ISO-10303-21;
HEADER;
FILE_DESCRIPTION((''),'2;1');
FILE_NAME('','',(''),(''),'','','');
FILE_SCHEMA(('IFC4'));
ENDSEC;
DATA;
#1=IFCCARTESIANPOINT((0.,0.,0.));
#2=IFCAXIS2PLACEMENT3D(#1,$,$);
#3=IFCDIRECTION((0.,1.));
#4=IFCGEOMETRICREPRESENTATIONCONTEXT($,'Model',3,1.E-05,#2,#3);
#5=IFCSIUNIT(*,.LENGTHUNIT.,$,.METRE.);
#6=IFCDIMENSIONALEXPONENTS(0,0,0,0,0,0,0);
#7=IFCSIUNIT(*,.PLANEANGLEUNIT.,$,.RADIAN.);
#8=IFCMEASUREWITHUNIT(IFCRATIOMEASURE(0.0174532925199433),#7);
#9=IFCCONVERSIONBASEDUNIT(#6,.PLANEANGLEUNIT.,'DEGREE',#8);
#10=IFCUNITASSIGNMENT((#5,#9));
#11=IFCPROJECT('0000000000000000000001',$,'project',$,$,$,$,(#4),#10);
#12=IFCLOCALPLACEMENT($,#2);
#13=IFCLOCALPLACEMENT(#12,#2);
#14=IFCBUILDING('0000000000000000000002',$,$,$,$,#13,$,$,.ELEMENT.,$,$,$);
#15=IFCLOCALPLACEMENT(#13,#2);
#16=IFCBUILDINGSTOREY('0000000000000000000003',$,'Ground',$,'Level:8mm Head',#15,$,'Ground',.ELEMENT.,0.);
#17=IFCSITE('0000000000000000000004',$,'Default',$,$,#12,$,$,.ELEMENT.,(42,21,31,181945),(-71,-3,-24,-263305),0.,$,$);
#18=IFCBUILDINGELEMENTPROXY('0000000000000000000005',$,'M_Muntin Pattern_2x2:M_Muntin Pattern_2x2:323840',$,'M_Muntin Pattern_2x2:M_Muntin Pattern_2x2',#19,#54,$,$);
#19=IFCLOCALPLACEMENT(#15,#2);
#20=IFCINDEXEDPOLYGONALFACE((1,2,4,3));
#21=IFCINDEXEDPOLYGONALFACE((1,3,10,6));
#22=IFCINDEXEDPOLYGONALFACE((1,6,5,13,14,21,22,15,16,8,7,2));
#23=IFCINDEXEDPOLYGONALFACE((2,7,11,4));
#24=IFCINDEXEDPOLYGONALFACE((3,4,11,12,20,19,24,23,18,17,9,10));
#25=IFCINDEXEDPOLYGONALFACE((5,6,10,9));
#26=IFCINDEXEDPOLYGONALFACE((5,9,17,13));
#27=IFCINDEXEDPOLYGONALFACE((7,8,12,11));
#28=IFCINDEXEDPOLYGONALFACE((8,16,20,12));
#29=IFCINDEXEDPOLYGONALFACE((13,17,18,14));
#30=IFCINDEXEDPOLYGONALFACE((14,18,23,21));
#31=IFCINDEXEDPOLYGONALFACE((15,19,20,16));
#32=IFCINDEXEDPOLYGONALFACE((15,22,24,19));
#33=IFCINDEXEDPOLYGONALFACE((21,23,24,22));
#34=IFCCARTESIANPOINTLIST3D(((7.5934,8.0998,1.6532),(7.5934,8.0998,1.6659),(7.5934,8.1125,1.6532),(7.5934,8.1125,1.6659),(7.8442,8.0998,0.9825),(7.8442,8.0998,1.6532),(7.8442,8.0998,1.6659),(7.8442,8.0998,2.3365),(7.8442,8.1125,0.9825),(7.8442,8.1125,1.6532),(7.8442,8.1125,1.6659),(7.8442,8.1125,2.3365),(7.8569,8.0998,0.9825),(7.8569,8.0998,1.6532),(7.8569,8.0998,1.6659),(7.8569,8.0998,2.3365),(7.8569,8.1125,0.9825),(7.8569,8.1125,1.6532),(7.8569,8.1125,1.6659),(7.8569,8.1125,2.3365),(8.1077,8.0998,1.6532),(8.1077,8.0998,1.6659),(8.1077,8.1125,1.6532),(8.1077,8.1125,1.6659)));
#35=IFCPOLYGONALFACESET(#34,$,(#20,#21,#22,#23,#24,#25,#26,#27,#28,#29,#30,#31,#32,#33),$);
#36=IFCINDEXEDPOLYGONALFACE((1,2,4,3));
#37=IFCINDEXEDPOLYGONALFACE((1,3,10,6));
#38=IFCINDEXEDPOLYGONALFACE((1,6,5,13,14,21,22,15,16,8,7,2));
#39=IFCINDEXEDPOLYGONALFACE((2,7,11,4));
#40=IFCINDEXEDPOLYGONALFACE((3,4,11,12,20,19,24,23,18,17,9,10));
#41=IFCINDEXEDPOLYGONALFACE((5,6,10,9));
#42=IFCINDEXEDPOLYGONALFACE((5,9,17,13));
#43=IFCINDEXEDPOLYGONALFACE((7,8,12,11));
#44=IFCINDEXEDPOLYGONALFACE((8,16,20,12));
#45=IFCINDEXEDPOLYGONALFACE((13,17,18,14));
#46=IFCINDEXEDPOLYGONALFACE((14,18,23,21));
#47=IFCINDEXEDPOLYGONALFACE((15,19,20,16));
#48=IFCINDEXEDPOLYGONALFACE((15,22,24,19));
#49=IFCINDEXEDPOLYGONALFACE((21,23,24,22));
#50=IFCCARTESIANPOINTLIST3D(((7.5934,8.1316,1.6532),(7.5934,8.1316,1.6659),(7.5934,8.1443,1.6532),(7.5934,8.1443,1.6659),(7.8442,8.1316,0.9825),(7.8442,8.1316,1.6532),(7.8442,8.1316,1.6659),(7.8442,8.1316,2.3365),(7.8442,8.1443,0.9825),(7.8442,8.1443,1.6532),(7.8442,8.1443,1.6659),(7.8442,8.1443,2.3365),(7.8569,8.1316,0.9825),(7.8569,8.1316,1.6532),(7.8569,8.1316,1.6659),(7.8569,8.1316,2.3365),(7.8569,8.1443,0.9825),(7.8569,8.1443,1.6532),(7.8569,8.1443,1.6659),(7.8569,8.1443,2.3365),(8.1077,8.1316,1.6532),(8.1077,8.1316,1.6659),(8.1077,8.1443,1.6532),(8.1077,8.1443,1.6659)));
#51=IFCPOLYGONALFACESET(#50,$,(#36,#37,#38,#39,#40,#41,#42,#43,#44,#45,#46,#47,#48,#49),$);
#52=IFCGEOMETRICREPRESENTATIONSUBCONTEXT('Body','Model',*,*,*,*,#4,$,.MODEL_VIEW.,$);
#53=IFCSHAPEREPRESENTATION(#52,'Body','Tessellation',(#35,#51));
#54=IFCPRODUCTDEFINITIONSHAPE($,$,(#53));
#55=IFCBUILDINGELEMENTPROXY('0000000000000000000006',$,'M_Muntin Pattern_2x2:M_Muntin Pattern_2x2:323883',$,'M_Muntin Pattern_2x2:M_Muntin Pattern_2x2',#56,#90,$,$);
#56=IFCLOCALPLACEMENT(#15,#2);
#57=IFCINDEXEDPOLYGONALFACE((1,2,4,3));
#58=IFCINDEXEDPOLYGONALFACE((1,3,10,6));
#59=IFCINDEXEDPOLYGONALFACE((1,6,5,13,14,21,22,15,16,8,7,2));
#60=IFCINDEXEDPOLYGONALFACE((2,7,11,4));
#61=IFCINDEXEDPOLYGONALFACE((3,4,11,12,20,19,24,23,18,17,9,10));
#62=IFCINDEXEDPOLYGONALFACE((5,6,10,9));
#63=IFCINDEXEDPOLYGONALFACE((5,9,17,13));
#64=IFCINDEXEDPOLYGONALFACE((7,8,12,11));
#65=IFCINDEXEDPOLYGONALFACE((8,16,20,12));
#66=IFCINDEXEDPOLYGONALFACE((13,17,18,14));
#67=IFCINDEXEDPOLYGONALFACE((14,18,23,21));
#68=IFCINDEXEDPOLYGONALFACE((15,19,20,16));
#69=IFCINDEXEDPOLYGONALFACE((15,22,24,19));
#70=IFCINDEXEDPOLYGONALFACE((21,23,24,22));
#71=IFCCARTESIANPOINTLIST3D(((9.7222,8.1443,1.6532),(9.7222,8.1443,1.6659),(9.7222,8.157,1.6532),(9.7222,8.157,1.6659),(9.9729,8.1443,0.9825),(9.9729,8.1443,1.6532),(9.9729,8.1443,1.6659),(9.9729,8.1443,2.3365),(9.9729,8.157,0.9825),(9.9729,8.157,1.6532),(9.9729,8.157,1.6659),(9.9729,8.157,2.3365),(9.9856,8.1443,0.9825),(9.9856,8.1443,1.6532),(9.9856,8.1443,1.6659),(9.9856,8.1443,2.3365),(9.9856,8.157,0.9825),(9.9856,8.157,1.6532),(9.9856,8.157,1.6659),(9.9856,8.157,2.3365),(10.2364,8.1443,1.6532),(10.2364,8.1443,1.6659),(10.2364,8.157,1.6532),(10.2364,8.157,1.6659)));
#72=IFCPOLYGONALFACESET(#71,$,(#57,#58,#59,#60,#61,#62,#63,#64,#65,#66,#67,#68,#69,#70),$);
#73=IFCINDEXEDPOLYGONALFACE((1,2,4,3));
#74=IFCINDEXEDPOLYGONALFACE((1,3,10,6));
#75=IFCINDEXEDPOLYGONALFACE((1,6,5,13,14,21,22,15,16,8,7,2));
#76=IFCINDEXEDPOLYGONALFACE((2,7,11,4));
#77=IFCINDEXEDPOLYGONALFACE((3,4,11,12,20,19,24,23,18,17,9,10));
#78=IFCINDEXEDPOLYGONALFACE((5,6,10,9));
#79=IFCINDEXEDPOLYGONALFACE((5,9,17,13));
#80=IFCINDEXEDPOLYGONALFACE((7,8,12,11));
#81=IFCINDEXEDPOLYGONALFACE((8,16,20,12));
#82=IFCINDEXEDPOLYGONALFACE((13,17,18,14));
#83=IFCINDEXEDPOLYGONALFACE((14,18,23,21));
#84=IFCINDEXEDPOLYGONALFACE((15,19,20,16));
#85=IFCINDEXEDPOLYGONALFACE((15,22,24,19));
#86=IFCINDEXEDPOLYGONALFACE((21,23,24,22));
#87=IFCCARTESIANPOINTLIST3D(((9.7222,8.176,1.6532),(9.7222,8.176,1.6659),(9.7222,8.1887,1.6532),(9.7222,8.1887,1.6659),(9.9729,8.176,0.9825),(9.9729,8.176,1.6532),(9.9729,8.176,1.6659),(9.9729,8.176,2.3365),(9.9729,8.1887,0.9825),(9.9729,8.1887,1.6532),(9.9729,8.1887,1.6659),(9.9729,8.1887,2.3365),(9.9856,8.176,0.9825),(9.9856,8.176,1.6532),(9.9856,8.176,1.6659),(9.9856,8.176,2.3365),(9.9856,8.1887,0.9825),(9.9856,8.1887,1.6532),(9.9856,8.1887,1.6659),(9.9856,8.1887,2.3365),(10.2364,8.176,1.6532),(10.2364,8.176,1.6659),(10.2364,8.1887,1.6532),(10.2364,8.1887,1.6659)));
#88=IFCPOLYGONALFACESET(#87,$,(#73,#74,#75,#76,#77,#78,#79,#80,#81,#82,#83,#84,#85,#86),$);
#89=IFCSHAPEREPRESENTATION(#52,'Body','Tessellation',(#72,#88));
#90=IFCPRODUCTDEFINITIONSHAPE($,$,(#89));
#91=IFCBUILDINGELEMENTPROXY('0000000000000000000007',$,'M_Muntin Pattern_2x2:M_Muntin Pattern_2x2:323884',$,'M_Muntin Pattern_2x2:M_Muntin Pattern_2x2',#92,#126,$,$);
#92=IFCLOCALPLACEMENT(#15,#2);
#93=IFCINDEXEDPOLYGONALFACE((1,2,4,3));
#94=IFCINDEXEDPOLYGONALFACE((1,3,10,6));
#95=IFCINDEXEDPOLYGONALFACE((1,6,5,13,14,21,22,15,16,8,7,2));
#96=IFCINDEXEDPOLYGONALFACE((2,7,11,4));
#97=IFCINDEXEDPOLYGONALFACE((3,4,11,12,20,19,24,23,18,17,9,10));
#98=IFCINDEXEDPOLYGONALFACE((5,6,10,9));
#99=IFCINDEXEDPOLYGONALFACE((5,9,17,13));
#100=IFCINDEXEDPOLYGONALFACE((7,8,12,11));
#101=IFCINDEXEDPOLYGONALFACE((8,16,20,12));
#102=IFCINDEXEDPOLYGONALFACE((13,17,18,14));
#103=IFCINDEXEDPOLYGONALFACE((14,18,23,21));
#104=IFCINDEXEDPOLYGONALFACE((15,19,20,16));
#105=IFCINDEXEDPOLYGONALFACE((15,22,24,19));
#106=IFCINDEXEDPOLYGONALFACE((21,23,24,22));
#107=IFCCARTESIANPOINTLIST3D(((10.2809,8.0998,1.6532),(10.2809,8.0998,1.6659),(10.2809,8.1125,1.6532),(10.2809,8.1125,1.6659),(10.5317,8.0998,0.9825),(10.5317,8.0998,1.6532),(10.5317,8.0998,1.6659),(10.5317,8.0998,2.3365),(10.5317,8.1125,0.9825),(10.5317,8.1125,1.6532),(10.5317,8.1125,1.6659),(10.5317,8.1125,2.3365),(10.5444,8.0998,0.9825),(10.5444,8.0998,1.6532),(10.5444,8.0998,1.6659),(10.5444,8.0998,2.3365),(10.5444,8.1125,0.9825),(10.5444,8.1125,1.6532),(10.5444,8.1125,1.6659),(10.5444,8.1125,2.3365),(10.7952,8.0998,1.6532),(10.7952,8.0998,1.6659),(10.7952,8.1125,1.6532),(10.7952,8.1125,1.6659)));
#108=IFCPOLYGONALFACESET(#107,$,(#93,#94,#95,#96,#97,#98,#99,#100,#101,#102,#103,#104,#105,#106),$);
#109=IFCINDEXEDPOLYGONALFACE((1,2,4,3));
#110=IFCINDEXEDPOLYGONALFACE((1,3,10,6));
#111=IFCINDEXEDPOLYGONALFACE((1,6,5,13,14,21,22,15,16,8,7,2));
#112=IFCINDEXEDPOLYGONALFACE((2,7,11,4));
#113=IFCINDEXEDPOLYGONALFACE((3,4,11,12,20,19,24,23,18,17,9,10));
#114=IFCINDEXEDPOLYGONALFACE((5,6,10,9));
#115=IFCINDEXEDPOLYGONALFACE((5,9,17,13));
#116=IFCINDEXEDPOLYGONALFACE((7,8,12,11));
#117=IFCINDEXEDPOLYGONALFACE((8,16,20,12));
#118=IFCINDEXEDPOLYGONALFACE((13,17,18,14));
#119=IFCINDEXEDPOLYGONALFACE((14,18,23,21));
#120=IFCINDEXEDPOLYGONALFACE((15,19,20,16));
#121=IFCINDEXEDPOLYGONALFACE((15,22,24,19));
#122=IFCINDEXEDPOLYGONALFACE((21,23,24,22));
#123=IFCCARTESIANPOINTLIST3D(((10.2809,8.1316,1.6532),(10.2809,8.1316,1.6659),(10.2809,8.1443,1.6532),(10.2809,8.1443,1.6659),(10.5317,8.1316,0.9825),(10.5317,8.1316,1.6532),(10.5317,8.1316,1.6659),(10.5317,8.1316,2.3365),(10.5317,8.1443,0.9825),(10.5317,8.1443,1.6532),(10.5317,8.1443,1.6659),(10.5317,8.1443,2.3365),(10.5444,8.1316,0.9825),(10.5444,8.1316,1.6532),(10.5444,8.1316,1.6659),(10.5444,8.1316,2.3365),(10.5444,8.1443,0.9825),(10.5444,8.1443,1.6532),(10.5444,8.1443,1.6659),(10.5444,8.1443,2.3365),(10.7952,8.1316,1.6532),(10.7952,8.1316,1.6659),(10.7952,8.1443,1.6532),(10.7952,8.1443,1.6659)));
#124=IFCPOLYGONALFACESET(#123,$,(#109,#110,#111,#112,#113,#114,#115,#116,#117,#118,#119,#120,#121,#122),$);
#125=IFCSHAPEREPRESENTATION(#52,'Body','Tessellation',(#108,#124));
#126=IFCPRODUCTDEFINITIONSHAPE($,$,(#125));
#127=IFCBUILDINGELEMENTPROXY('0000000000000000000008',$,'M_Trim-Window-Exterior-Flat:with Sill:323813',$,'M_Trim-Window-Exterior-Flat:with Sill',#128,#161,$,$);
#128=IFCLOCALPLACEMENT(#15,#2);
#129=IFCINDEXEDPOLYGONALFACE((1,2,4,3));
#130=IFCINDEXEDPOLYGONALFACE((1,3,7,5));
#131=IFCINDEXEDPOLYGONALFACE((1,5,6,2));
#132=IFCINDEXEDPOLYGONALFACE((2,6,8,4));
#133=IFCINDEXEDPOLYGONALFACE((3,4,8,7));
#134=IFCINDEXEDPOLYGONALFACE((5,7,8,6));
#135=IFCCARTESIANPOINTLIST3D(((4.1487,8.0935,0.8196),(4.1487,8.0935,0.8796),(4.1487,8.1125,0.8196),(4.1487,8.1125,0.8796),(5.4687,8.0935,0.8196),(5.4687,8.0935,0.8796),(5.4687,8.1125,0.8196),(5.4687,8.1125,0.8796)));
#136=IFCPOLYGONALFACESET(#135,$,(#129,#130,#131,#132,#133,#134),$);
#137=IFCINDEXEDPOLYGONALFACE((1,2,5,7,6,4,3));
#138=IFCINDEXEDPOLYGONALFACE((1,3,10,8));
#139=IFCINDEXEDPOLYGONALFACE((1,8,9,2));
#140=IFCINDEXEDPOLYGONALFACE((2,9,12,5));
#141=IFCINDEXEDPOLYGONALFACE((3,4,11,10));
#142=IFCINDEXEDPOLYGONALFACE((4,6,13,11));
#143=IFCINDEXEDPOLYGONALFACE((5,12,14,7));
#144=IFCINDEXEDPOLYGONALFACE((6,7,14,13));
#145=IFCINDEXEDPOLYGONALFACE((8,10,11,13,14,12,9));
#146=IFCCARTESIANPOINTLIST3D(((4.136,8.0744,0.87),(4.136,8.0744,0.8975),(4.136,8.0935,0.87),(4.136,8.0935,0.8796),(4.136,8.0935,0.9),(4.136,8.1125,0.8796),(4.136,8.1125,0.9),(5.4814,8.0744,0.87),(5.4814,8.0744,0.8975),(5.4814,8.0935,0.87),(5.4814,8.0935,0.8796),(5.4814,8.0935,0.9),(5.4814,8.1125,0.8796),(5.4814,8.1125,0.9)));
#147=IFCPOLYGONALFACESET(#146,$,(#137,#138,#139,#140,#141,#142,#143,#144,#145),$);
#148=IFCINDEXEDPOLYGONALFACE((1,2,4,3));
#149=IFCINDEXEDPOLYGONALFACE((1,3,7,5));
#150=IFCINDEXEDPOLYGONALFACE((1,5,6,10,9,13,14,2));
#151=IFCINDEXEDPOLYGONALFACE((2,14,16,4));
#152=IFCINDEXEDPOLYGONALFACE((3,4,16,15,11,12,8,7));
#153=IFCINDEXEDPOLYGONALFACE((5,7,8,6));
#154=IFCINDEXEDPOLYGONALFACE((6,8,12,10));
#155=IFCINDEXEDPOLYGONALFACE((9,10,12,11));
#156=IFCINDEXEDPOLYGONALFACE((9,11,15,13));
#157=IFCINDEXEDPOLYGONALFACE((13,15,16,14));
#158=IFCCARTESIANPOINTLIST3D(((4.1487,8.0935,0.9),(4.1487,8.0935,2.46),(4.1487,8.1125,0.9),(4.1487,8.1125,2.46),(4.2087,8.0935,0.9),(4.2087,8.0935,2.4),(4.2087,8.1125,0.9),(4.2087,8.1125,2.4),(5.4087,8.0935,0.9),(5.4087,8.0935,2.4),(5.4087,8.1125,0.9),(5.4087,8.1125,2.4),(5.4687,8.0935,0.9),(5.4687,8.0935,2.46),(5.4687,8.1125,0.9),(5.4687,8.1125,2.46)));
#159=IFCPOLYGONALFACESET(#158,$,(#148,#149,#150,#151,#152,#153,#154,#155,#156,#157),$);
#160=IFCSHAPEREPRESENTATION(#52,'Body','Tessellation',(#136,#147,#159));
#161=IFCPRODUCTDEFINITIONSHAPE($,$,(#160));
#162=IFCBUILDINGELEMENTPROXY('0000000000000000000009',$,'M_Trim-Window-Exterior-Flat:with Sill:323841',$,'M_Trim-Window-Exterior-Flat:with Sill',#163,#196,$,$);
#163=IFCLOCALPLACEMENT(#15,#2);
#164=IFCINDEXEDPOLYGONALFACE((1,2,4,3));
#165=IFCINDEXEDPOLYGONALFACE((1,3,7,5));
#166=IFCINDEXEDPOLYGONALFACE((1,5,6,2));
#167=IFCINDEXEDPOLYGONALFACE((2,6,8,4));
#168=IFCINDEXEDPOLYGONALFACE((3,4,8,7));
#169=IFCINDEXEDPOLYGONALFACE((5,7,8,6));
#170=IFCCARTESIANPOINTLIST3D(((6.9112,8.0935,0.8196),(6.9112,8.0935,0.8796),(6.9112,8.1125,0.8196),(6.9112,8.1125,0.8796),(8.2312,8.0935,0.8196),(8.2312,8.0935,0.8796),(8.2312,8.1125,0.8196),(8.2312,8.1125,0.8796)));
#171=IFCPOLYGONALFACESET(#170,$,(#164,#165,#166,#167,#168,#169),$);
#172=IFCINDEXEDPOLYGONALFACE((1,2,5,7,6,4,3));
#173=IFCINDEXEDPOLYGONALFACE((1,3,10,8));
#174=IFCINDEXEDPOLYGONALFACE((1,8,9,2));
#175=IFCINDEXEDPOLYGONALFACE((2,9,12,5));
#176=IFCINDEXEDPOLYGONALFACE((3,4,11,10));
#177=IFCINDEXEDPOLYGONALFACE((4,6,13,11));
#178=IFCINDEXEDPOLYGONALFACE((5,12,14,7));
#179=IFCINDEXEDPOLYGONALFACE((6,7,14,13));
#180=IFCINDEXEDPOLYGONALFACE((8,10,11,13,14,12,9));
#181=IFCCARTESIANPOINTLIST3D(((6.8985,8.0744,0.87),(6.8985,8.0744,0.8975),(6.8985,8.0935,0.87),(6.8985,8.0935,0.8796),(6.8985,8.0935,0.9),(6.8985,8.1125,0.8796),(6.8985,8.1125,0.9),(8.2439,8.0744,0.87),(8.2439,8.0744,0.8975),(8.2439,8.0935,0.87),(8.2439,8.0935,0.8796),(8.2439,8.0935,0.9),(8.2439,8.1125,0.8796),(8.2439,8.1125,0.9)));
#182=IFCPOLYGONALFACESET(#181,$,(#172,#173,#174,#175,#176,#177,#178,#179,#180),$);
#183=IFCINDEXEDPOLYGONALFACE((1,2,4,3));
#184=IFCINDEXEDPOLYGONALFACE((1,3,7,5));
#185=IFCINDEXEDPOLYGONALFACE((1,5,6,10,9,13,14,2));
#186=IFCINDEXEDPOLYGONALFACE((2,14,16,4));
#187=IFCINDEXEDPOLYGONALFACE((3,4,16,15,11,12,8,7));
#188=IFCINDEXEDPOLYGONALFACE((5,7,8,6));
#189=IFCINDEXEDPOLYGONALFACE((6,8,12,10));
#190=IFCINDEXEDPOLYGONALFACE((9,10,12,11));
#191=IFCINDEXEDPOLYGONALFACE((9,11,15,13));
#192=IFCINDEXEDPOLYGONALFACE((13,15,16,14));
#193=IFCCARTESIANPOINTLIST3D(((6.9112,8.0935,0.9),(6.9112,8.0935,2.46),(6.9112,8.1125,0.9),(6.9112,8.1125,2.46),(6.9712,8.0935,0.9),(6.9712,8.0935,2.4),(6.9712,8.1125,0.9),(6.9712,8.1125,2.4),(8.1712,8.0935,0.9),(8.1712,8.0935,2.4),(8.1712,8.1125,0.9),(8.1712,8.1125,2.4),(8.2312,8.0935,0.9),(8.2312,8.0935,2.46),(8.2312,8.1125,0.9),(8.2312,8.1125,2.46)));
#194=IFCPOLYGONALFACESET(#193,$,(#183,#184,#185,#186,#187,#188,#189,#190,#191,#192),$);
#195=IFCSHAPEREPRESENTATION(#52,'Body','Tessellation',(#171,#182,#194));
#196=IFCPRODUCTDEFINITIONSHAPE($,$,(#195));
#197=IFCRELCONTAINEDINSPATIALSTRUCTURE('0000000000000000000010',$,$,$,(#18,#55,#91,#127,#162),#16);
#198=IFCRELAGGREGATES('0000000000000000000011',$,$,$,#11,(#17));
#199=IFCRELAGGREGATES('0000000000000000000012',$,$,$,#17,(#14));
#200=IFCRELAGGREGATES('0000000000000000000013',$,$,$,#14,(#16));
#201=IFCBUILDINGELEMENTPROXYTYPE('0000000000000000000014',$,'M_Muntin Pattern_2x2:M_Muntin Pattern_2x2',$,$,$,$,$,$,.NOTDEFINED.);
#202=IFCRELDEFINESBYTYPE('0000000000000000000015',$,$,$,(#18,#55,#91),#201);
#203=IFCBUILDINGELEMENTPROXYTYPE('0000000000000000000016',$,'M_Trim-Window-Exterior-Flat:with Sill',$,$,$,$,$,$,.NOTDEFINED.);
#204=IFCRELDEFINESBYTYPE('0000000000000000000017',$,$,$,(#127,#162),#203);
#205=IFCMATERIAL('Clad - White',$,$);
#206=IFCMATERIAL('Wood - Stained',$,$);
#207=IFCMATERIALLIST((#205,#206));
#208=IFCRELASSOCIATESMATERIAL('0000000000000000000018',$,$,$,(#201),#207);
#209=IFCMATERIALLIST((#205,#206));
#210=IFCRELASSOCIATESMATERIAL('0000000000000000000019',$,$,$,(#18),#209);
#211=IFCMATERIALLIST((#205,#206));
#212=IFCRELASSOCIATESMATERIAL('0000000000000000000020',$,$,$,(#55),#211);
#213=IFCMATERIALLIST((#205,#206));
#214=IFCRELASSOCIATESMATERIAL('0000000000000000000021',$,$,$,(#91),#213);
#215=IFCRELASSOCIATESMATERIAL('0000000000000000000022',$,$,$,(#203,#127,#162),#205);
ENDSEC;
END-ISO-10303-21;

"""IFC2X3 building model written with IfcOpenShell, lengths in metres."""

from ifc_helpers import new_model, entity, si_unit, converted_unit, direction, frame, frame_2d, origin, place, context, subcontext, project, spatial, polyline, rectangle, outline, extrude, source, transform, mapped, material, material_list, type_object, type_shapes, element, save


model = new_model("IFC2X3")

# Units and contexts
model_context = context("Model", 3, precision=1e-05, world=origin(), true_north=direction((0.0, 1.0)))
body_context = subcontext(model_context, "Body", "Model", "MODEL_VIEW")
ifc_project = project(units=[si_unit("LENGTHUNIT", "METRE"), converted_unit("PLANEANGLEUNIT", "DEGREE", entity("IfcRatioMeasure", 0.0174532925199433), si_unit("PLANEANGLEUNIT", "RADIAN"), dimensions=[0, 0, 0, 0, 0, 0, 0])], contexts=[model_context])

# Site, building, storey
site_placement = place(None, origin())
site = spatial("IfcSite", under=ifc_project, at=site_placement, Name="Default", CompositionType="ELEMENT", RefLatitude=(42, 21, 31, 181945), RefLongitude=(-71, -3, -24, -263305), RefElevation=0.0)
building_placement = place(site_placement, origin())
building = spatial("IfcBuilding", under=site, at=building_placement, CompositionType="ELEMENT")
storey_placement = place(building_placement, origin())
storey = spatial("IfcBuildingStorey", under=building, at=storey_placement, Name="Ground", ObjectType="Level:8mm Head", LongName="Ground", CompositionType="ELEMENT", Elevation=0.0)

# Building element proxies
ifc_material_1 = material(Name="Clad - White")
ifc_material_2 = material(Name="Wood - Stained")
ifc_material_list_1 = material_list([ifc_material_1, ifc_material_2])
building_element_proxy_type_1 = type_object("IfcBuildingElementProxyType", Name="M_Muntin Pattern_2x2:M_Muntin Pattern_2x2", PredefinedType="NOTDEFINED", material=ifc_material_list_1)
shared_shape_1 = source(origin(), body_context, "Body", "SweptSolid", [
    extrude(outline(polyline([(0.0064, -0.0064), (0.677, -0.0064), (0.677, 0.0063), (0.0064, 0.0063), (0.0064, 0.2571), (-0.0063, 0.2571), (-0.0063, 0.0063), (-0.677, 0.0063), (-0.677, -0.0064), (-0.0063, -0.0064), (-0.0063, -0.2571), (0.0064, -0.2571), (0.0064, -0.0064)])), frame((0.0, 0.0095, 0.677), z_axis=(0.0, 1.0, 0.0), x_axis=(0.0, 0.0, 1.0)), (0.0, 0.0, 1.0), 0.0127),
    extrude(outline(polyline([(0.0064, -0.0064), (0.677, -0.0064), (0.677, 0.0063), (0.0064, 0.0063), (0.0064, 0.2571), (-0.0063, 0.2571), (-0.0063, 0.0063), (-0.677, 0.0063), (-0.677, -0.0064), (-0.0063, -0.0064), (-0.0063, -0.2571), (0.0064, -0.2571), (0.0064, -0.0064)])), frame((0.0, -0.0222, 0.677), z_axis=(0.0, 1.0, 0.0), x_axis=(0.0, 0.0, 1.0)), (0.0, 0.0, 1.0), 0.0127),
])
type_shapes(building_element_proxy_type_1, [shared_shape_1])
ifc_material_list_2 = material_list([ifc_material_1, ifc_material_2])
proxy_1_placement = place(storey_placement, frame((7.8505, 8.1221, 0.9825), z_axis=(0.0, 0.0, 1.0), x_axis=(-1.0, 0.0, 0.0)))
element("IfcBuildingElementProxy", 1, at=proxy_1_placement, inside=storey, type_object=building_element_proxy_type_1, material=ifc_material_list_2, Name="M_Muntin Pattern_2x2:M_Muntin Pattern_2x2:323840", ObjectType="M_Muntin Pattern_2x2:M_Muntin Pattern_2x2", context=body_context, shape_type="MappedRepresentation", body=[
    mapped(shared_shape_1, transform((0.0, 0.0, 0.0), scale=1.0)),
])
ifc_material_list_3 = material_list([ifc_material_1, ifc_material_2])
proxy_2_placement = place(storey_placement, frame((9.9793, 8.1665, 0.9825), z_axis=(0.0, 0.0, 1.0), x_axis=(-1.0, 0.0, 0.0)))
element("IfcBuildingElementProxy", 2, at=proxy_2_placement, inside=storey, type_object=building_element_proxy_type_1, material=ifc_material_list_3, Name="M_Muntin Pattern_2x2:M_Muntin Pattern_2x2:323883", ObjectType="M_Muntin Pattern_2x2:M_Muntin Pattern_2x2", context=body_context, shape_type="MappedRepresentation", body=[
    mapped(shared_shape_1, transform((0.0, 0.0, 0.0), scale=1.0)),
])
ifc_material_list_4 = material_list([ifc_material_1, ifc_material_2])
proxy_3_placement = place(storey_placement, frame((10.538, 8.1221, 0.9825), z_axis=(0.0, 0.0, 1.0), x_axis=(-1.0, 0.0, 0.0)))
element("IfcBuildingElementProxy", 3, at=proxy_3_placement, inside=storey, type_object=building_element_proxy_type_1, material=ifc_material_list_4, Name="M_Muntin Pattern_2x2:M_Muntin Pattern_2x2:323884", ObjectType="M_Muntin Pattern_2x2:M_Muntin Pattern_2x2", context=body_context, shape_type="MappedRepresentation", body=[
    mapped(shared_shape_1, transform((0.0, 0.0, 0.0), scale=1.0)),
])
building_element_proxy_type_2 = type_object("IfcBuildingElementProxyType", Name="M_Trim-Window-Exterior-Flat:with Sill", PredefinedType="NOTDEFINED", material=ifc_material_1)
shared_shape_2 = source(origin(), body_context, "Body", "SweptSolid", [
    extrude(rectangle(XDim=1.32, YDim=0.06, at=frame_2d((0.0, 0.0), x_axis=(1.0, 0.0))), frame((0.0, -1.5504, 0.0), z_axis=(0.0, 0.0, 1.0), x_axis=(-1.0, 0.0, 0.0)), (0.0, 0.0, 1.0), 0.0191),
    extrude(outline(polyline([(-0.019, -0.0152), (0.0, -0.0152), (0.0, -0.0057), (0.019, -0.0057), (0.019, 0.0148), (0.0, 0.0148), (-0.019, 0.0123), (-0.019, -0.0152)])), frame((-0.6727, -1.5148, 0.019), z_axis=(1.0, 0.0, 0.0), x_axis=(0.0, 0.0, -1.0)), (0.0, 0.0, 1.0), 1.3454),
    extrude(outline(polyline([(-0.795, -0.66), (0.765, -0.66), (0.765, -0.6), (-0.735, -0.6), (-0.735, 0.6), (0.765, 0.6), (0.765, 0.66), (-0.795, 0.66), (-0.795, -0.66)])), frame((0.0, -0.735, 0.0), z_axis=(0.0, 0.0, 1.0), x_axis=(0.0, -1.0, 0.0)), (0.0, 0.0, 1.0), 0.0191),
])
type_shapes(building_element_proxy_type_2, [shared_shape_2])
for number, where, z_axis, x_axis, name in (
    (4, (4.8087, 8.1125, 2.4), (0.0, -1.0, 0.0), (1.0, 0.0, 0.0), "M_Trim-Window-Exterior-Flat:with Sill:323813"),
    (5, (7.5712, 8.1125, 2.4), (0.0, -1.0, 0.0), (1.0, 0.0, 0.0), "M_Trim-Window-Exterior-Flat:with Sill:323841"),
):
    element("IfcBuildingElementProxy", number, at=place(storey_placement, frame(where, z_axis=z_axis, x_axis=x_axis)), inside=storey, type_object=building_element_proxy_type_2, material=ifc_material_1, Name=name, ObjectType="M_Trim-Window-Exterior-Flat:with Sill", context=body_context, shape_type="MappedRepresentation", body=[
        mapped(shared_shape_2, transform((0.0, 0.0, 0.0), scale=1.0)),
    ])

save(model, "model.ifc")
